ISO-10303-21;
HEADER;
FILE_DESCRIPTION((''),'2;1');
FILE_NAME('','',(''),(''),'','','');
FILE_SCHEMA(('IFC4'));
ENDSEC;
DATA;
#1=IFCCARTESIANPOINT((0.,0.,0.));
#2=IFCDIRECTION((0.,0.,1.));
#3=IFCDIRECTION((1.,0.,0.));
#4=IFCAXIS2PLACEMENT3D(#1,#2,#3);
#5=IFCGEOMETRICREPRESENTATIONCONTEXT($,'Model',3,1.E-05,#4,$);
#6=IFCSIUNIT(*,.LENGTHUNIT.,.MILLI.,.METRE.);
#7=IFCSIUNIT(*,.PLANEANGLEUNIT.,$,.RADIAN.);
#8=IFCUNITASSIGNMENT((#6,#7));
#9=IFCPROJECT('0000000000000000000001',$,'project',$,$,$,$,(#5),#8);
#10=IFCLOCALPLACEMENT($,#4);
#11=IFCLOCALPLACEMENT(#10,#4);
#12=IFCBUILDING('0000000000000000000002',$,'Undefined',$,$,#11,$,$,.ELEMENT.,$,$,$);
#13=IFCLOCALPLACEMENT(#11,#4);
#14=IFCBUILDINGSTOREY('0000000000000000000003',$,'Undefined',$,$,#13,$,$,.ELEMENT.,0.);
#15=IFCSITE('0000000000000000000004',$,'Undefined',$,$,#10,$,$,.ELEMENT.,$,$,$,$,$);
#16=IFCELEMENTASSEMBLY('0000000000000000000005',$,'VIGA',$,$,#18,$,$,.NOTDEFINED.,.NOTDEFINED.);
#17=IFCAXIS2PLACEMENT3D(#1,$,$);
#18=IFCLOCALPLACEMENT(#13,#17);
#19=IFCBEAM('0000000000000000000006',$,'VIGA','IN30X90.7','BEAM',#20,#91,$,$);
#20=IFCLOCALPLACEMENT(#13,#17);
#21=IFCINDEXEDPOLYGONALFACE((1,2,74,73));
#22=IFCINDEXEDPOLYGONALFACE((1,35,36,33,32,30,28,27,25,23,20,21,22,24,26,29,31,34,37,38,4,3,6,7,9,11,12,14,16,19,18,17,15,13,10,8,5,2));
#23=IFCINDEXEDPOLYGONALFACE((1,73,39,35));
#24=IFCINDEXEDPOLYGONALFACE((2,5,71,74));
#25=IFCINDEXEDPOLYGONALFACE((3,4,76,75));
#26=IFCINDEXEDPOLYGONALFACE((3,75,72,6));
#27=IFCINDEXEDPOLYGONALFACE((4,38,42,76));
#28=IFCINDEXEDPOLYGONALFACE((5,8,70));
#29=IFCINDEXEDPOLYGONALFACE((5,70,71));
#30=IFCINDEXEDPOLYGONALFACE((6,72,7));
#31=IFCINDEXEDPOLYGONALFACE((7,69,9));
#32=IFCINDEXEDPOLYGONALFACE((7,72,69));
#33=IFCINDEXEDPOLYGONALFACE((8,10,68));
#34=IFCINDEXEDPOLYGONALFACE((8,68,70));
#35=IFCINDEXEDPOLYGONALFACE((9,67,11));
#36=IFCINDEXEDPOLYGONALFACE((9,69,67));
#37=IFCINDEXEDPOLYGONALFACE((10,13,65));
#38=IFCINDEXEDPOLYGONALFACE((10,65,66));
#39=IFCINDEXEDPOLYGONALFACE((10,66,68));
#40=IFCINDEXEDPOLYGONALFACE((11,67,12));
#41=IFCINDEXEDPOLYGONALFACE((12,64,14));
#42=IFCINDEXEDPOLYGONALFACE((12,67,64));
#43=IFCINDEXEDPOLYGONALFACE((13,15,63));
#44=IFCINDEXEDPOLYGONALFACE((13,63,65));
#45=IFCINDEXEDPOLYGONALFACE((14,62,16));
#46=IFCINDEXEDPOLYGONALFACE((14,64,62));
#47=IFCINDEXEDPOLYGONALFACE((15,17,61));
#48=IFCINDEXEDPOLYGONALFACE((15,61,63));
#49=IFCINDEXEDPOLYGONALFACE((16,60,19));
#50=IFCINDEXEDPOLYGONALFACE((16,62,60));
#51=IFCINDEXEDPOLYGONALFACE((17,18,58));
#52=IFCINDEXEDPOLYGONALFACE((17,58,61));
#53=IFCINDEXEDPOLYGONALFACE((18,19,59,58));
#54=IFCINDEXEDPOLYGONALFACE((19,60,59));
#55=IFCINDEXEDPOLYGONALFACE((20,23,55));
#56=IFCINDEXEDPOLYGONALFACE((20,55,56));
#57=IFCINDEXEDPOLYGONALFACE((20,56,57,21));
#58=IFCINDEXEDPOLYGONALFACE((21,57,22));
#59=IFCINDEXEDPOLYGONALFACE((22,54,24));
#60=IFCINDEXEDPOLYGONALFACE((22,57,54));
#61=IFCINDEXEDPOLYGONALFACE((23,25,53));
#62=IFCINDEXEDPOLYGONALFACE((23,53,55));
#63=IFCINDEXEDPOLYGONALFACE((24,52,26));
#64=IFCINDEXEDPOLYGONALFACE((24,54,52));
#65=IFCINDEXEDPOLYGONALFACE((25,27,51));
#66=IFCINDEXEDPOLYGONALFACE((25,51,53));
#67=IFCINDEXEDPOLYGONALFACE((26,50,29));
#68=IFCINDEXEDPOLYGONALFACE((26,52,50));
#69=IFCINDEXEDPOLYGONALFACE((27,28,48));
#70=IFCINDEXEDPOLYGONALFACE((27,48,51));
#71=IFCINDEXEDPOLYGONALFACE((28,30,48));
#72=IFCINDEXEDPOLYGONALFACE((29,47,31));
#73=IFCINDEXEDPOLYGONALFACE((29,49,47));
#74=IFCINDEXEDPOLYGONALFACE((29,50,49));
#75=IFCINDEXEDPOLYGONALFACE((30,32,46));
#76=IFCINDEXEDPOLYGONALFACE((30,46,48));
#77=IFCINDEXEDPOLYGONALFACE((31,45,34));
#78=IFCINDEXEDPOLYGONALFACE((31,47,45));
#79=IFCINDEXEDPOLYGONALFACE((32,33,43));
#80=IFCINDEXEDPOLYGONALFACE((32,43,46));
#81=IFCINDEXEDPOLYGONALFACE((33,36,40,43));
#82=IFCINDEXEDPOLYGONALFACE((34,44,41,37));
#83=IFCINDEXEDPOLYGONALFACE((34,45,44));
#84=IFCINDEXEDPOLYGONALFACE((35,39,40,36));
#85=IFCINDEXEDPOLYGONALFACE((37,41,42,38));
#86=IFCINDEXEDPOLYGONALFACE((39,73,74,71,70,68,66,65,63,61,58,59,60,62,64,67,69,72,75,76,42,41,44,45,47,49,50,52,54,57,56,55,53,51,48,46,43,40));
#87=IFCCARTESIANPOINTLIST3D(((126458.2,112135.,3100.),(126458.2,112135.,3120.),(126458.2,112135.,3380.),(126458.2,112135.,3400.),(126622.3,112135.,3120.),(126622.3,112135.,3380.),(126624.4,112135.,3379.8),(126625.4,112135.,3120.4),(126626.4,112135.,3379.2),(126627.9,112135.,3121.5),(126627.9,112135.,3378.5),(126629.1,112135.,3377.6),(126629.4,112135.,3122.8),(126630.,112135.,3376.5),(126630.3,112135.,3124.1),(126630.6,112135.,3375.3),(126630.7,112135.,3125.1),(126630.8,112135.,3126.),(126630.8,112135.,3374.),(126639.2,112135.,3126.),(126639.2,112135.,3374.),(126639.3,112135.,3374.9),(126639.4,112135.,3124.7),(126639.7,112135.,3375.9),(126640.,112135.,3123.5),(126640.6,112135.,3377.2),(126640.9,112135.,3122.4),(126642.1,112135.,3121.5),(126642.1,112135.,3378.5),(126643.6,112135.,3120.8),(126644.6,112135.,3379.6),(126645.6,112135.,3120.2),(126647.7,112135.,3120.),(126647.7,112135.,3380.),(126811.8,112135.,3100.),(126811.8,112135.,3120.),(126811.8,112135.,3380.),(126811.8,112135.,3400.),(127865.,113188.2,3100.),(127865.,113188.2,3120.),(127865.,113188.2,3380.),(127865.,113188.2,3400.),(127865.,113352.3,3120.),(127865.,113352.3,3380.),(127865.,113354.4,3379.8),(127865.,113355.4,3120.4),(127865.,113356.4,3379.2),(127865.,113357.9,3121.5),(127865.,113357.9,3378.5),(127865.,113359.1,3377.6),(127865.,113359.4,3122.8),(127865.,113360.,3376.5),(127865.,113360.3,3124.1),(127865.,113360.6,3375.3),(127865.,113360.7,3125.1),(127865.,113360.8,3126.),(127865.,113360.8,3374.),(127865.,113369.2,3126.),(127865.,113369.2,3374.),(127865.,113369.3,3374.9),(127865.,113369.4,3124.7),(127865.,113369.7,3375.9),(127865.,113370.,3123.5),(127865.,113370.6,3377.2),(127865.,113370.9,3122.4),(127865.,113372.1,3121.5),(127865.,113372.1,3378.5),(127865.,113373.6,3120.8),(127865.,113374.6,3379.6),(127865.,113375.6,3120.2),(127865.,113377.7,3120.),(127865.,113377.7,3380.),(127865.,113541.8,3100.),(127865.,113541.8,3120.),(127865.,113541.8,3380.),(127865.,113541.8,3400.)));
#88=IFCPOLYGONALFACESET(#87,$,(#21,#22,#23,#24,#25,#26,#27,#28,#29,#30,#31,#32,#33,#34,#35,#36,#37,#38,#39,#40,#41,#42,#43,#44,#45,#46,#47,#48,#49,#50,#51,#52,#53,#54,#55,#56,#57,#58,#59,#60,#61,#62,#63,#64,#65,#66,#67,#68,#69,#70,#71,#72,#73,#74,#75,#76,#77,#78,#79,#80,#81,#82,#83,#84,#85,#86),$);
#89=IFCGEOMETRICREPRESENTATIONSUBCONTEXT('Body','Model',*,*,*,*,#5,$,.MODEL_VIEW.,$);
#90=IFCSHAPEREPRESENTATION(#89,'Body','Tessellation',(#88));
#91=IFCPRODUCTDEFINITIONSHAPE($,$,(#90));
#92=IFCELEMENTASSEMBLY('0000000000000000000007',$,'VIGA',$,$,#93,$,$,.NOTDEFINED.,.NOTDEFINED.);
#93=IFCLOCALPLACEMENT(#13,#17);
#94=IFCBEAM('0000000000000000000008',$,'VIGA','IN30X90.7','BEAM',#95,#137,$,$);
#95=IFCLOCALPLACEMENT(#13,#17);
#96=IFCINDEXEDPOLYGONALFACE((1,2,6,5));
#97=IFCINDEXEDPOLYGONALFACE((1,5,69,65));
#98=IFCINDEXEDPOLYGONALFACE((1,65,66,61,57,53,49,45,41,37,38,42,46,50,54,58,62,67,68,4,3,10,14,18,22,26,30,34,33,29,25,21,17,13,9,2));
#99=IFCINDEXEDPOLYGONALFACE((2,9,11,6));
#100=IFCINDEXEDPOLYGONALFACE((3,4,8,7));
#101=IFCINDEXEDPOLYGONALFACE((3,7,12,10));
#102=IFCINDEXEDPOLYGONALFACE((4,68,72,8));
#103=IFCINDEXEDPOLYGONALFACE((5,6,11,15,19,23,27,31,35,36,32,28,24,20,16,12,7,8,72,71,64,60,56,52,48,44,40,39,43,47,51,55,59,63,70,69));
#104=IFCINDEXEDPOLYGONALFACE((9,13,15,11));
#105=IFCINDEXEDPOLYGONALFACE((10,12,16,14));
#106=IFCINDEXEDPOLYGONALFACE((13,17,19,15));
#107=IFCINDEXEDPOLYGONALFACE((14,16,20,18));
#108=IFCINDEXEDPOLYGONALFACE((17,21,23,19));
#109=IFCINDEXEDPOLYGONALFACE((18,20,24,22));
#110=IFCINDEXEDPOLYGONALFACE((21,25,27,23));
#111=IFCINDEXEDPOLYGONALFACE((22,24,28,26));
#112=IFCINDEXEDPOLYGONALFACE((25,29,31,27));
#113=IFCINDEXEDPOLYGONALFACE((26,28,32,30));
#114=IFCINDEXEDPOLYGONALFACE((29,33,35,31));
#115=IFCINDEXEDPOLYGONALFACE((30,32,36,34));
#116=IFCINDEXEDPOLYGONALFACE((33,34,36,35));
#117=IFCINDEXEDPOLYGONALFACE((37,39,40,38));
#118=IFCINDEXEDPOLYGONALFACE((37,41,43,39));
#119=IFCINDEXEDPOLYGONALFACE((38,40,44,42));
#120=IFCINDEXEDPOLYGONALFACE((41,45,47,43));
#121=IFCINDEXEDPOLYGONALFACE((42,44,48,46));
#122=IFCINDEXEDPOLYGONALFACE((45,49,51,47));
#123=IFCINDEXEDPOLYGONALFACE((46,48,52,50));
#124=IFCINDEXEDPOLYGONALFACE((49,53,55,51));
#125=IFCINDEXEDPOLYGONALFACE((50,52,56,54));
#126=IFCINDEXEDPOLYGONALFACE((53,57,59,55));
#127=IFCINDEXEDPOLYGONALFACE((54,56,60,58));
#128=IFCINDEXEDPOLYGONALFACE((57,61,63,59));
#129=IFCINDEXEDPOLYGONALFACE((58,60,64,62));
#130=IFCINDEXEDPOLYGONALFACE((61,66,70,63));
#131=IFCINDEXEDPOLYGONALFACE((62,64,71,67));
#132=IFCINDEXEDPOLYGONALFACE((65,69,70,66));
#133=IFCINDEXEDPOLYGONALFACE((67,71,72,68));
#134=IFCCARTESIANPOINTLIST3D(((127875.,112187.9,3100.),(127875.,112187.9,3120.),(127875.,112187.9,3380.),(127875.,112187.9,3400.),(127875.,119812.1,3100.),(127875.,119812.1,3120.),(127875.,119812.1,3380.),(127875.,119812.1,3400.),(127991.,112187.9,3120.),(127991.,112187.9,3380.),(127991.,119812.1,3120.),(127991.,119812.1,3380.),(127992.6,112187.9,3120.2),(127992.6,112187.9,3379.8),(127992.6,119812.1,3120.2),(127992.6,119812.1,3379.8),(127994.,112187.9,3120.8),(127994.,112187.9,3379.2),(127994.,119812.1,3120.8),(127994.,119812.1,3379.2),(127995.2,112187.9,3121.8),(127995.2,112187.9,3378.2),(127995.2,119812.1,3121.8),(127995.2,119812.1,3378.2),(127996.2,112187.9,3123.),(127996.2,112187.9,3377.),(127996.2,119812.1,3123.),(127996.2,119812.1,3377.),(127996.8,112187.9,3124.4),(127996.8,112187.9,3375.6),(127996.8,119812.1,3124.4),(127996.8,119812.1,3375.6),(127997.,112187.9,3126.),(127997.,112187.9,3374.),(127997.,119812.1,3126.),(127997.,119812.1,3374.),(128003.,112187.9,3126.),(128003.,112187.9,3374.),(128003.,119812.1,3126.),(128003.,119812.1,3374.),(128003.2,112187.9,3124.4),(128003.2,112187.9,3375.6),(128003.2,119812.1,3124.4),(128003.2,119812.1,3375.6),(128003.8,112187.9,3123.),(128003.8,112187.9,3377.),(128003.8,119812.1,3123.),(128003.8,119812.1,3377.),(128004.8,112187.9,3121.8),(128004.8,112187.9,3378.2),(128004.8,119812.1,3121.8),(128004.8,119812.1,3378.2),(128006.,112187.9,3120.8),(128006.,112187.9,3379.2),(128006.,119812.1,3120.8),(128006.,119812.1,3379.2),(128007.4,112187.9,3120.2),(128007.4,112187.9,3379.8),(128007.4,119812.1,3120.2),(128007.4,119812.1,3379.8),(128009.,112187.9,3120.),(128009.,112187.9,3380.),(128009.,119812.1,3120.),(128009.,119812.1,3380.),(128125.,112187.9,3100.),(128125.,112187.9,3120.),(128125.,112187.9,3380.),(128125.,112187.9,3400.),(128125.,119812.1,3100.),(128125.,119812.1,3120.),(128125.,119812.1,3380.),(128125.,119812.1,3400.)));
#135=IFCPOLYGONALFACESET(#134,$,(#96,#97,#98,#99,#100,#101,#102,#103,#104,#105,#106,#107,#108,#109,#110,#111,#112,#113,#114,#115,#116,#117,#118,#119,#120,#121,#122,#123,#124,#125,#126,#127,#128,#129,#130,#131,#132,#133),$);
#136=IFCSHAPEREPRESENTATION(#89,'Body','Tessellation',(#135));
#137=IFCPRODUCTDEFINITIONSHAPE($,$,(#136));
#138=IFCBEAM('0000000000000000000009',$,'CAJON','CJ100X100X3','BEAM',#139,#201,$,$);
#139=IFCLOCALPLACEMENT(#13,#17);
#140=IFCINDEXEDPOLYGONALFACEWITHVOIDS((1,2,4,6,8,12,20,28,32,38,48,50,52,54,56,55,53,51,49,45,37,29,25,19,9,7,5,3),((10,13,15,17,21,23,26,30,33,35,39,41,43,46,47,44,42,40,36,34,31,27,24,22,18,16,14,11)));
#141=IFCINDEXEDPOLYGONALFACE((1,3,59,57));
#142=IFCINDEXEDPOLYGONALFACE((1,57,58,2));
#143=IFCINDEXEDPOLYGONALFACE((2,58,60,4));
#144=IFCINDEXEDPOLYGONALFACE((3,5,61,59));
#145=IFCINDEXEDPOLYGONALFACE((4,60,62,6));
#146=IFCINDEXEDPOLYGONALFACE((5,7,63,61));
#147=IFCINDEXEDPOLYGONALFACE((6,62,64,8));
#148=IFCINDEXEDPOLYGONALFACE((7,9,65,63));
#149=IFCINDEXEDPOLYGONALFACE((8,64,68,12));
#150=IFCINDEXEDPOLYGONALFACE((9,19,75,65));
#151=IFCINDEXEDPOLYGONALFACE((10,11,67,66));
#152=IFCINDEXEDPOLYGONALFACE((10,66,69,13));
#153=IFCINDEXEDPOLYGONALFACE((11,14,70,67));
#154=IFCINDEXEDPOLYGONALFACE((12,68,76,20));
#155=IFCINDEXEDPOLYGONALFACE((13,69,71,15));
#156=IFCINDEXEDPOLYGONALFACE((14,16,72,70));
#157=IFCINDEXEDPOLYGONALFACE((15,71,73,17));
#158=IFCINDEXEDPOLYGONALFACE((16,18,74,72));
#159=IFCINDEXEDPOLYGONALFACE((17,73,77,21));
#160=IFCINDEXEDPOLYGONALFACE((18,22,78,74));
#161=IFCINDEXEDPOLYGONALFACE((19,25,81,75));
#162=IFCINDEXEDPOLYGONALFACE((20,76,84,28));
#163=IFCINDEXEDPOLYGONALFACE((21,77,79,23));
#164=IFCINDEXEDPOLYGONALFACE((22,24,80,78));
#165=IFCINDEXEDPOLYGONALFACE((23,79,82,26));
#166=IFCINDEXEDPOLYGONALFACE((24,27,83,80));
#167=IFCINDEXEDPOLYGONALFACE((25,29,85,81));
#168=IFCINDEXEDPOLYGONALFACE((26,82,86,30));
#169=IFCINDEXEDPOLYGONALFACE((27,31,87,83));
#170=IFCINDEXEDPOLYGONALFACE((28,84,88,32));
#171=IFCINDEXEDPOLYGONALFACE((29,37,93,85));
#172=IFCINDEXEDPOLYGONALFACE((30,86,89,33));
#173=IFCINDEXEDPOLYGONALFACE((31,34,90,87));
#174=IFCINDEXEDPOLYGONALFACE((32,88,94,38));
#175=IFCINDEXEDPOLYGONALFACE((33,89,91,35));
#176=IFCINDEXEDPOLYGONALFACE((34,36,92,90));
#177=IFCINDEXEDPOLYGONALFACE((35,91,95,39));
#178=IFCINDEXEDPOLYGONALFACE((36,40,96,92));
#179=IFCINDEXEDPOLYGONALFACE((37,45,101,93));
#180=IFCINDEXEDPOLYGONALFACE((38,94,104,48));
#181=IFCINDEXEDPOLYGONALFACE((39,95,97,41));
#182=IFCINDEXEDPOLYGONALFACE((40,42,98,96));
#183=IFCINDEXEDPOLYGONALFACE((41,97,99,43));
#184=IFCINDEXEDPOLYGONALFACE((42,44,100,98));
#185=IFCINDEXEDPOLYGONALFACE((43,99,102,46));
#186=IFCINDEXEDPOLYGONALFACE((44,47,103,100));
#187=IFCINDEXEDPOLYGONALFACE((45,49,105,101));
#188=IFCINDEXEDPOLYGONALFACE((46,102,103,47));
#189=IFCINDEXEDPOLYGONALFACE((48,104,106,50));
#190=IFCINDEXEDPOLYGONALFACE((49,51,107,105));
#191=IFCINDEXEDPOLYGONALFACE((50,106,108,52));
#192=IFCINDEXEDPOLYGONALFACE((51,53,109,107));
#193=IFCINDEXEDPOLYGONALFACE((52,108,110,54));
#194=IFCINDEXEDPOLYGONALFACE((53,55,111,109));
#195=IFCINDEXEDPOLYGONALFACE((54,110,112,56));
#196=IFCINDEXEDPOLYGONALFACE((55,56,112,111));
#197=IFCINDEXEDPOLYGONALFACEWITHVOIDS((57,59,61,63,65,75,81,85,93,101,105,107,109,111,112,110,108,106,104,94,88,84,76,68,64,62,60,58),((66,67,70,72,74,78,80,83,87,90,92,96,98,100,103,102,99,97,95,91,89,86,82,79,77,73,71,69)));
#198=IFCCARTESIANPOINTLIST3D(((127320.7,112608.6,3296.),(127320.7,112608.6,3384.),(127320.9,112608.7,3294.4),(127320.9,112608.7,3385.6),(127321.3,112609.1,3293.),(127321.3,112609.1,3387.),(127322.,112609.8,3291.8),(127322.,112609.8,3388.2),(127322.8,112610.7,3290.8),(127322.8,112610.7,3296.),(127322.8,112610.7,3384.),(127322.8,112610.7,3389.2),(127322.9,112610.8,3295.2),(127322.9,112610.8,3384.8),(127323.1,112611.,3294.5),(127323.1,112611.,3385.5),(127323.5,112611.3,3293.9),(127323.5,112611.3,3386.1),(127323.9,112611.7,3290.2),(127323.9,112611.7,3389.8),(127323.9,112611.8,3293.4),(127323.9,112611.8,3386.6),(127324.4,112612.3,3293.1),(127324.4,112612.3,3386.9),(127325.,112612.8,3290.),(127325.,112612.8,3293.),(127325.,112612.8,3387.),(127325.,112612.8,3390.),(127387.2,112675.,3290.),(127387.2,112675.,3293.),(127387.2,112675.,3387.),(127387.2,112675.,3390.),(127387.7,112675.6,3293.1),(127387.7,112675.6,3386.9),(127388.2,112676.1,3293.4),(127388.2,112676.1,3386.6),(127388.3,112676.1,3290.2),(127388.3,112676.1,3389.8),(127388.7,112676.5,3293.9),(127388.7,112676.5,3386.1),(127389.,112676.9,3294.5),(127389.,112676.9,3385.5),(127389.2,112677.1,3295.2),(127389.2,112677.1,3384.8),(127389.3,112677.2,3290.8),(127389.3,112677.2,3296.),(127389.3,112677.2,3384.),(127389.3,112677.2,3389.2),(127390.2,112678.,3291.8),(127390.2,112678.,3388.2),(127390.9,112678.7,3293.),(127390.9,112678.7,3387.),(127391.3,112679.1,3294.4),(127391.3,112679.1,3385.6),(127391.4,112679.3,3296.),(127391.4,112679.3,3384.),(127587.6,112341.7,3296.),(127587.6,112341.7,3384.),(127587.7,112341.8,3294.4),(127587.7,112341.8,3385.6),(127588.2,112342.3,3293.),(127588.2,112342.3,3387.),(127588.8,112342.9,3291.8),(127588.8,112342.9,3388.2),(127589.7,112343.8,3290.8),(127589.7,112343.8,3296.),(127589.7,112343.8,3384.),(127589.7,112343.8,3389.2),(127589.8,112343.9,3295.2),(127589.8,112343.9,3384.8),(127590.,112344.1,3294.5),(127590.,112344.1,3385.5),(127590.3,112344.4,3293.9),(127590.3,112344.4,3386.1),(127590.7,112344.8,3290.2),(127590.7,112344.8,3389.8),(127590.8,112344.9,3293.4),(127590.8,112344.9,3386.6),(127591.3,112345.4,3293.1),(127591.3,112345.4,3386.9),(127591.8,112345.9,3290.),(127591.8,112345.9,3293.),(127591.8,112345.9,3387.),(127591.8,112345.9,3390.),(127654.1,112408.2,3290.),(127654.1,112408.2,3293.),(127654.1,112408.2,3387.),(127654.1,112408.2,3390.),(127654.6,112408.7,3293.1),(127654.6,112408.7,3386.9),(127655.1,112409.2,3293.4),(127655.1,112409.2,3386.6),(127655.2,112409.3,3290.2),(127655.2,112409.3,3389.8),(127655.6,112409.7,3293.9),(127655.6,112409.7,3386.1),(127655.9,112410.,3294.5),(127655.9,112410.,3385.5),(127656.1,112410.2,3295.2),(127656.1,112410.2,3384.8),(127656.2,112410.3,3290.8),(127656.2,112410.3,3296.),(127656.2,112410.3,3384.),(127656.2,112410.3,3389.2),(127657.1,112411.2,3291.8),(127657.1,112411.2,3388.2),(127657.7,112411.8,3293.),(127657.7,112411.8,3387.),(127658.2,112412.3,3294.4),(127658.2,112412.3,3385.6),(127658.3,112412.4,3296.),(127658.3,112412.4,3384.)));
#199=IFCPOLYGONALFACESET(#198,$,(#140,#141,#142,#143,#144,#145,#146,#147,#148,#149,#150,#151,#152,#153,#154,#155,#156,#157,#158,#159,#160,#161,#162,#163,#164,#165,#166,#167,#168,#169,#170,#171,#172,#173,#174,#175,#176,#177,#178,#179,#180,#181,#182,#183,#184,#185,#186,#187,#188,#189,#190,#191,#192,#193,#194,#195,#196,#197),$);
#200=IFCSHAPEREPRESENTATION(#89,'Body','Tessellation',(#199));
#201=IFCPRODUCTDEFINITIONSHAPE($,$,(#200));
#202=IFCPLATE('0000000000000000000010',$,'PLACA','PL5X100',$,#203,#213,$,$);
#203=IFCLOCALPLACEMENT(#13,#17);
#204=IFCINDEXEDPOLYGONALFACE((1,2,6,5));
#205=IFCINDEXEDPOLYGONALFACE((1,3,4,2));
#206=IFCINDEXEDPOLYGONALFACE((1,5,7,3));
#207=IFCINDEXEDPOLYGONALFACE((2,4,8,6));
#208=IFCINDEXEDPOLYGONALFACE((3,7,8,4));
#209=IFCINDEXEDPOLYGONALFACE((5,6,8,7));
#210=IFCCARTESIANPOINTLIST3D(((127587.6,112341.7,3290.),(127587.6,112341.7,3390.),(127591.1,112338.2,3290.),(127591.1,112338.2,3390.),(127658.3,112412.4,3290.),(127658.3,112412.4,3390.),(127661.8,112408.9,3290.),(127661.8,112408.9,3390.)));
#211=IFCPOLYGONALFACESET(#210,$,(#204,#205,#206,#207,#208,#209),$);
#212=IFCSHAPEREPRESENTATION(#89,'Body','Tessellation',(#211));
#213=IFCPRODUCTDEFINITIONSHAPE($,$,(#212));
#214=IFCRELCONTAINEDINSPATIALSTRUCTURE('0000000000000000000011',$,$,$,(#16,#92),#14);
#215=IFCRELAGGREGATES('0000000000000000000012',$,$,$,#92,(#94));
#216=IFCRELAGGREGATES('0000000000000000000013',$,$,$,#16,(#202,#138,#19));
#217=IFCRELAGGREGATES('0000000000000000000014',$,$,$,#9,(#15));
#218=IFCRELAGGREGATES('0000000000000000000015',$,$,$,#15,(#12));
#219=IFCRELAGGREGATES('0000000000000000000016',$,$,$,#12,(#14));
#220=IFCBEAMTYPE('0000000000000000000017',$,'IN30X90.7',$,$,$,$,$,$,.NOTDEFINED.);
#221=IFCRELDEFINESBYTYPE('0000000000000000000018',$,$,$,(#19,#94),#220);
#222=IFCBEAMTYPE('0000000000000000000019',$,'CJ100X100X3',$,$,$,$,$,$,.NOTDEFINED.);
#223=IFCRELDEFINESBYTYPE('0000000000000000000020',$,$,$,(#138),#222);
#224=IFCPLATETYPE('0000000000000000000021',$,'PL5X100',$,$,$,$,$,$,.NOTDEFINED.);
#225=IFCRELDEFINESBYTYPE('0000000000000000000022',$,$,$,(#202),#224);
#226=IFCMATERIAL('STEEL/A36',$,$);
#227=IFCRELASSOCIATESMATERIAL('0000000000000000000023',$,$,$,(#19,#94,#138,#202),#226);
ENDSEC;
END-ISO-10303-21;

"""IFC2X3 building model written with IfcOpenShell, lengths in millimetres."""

from ifc_helpers import new_model, si_unit, frame, origin_with_axes, origin_2d_with_axis, place, context, subcontext, project, spatial, polyline, hollow_rectangle, i_section, outline, extrude, clip, halfspace, material, type_object, element, aggregate, save


model = new_model("IFC2X3")

# Units and contexts
model_context = context("Model", 3, precision=1e-05, world=origin_with_axes())
body_context = subcontext(model_context, "Body", "Model", "MODEL_VIEW")
ifc_project = project(units=[si_unit("LENGTHUNIT", "METRE", prefix="MILLI"), si_unit("PLANEANGLEUNIT", "RADIAN")], contexts=[model_context])

# Site, building, storey
site_placement = place(None, origin_with_axes())
site = spatial("IfcSite", under=ifc_project, at=site_placement, Name="Undefined", CompositionType="ELEMENT")
building_placement = place(site_placement, origin_with_axes())
building = spatial("IfcBuilding", under=site, at=building_placement, Name="Undefined", CompositionType="ELEMENT")
storey_placement = place(building_placement, origin_with_axes())
storey = spatial("IfcBuildingStorey", under=building, at=storey_placement, Name="Undefined", CompositionType="ELEMENT", Elevation=0.0)

# Element assembly
assembly_1_placement = place(storey_placement, origin_with_axes())
assembly_1 = element("IfcElementAssembly", 1, at=assembly_1_placement, inside=storey, Name="VIGA", AssemblyPlace="NOTDEFINED", PredefinedType="NOTDEFINED")
ifc_material_1 = material(Name="STEEL/A36")

# Beam
beam_type_1 = type_object("IfcBeamType", Name="IN30X90.7", PredefinedType="NOTDEFINED")
beam_1_placement = place(assembly_1_placement, frame((128000.0, 113500.0, 3250.0), z_axis=(0.0, 0.0, 1.0), x_axis=(-0.707107, -0.707107, 0.0)))
beam_1 = element("IfcBeam", 2, at=beam_1_placement, type_object=beam_type_1, material=ifc_material_1, Name="VIGA", Description="IN30X90.7", ObjectType="BEAM", context=body_context, shape_type="Clipping", body=[
    clip(clip(extrude(i_section(OverallWidth=250.0, OverallDepth=300.0, WebThickness=6.0, FlangeThickness=20.0, FilletRadius=6.0, at=origin_2d_with_axis()), frame((2182.9, 0.0, 0.0), z_axis=(-1.0, 0.0, 0.0), x_axis=(0.0, -1.0, 0.0)), (0.0, 0.0, 1.0), 2244.5), halfspace(frame((2023.7, -93.3, 250.0), z_axis=(0.707107, 0.707107, 0.0), x_axis=(-0.707107, 0.707107, 0.0)), False)), halfspace(frame((97.6, -93.3, 250.0), z_axis=(-0.707107, 0.707107, 0.0), x_axis=(-0.707107, -0.707107, 0.0)), False)),
])

# Element assembly, beam
assembly_2_placement = place(storey_placement, origin_with_axes())
assembly_2 = element("IfcElementAssembly", 3, at=assembly_2_placement, inside=storey, Name="VIGA", AssemblyPlace="NOTDEFINED", PredefinedType="NOTDEFINED")
beam_2_placement = place(assembly_2_placement, frame((128000.0, 112187.9, 3250.0), z_axis=(0.0, 0.0, 1.0), x_axis=(0.0, 1.0, 0.0)))
beam_2 = element("IfcBeam", 4, at=beam_2_placement, type_object=beam_type_1, material=ifc_material_1, Name="VIGA", Description="IN30X90.7", ObjectType="BEAM", context=body_context, shape_type="SweptSolid", body=[
    extrude(i_section(OverallWidth=250.0, OverallDepth=300.0, WebThickness=6.0, FlangeThickness=20.0, FilletRadius=6.0, at=origin_2d_with_axis()), frame((7624.2, 0.0, 0.0), z_axis=(-1.0, 0.0, 0.0), x_axis=(0.0, -1.0, 0.0)), (0.0, 0.0, 1.0), 7624.2),
])

# Beam
beam_type_2 = type_object("IfcBeamType", Name="CJ100X100X3", PredefinedType="NOTDEFINED")
beam_3_placement = place(assembly_1_placement, frame((127356.1, 112643.9, 3340.0), z_axis=(0.0, 0.0, 1.0), x_axis=(0.707107, -0.707107, 0.0)))
beam_3 = element("IfcBeam", 5, at=beam_3_placement, type_object=beam_type_2, material=ifc_material_1, Name="CAJON", Description="CJ100X100X3", ObjectType="BEAM", context=body_context, shape_type="SweptSolid", body=[
    extrude(hollow_rectangle(XDim=100.0, YDim=100.0, WallThickness=3.0, InnerFilletRadius=3.0, OuterFilletRadius=6.0, at=origin_2d_with_axis()), frame((377.4, 0.0, 0.0), z_axis=(-1.0, 0.0, 0.0), x_axis=(0.0, -1.0, 0.0)), (0.0, 0.0, 1.0), 377.4),
])

# Plate
plate_type_1 = type_object("IfcPlateType", Name="PL5X100", PredefinedType="NOTDEFINED")
plate_1_placement = place(assembly_1_placement, frame((127660.1, 112410.6, 3390.0), z_axis=(-0.707107, 0.707107, 0.0), x_axis=(0.0, 0.0, -1.0)))
plate_1 = element("IfcPlate", 6, at=plate_1_placement, type_object=plate_type_1, material=ifc_material_1, Name="PLACA", Description="PL5X100", context=body_context, shape_type="SweptSolid", body=[
    extrude(outline(polyline([(0.0, 0.0), (100.0, 0.0), (100.0, 100.0), (0.0, 100.0), (0.0, 0.0)])), frame((0.0, 0.0, -2.5), z_axis=(0.0, 0.0, 1.0), x_axis=(1.0, 0.0, 0.0)), (0.0, 0.0, 1.0), 5.0),
])

aggregate(assembly_2, [beam_2])

aggregate(assembly_1, [plate_1, beam_3, beam_1])

save(model, "model.ifc")
